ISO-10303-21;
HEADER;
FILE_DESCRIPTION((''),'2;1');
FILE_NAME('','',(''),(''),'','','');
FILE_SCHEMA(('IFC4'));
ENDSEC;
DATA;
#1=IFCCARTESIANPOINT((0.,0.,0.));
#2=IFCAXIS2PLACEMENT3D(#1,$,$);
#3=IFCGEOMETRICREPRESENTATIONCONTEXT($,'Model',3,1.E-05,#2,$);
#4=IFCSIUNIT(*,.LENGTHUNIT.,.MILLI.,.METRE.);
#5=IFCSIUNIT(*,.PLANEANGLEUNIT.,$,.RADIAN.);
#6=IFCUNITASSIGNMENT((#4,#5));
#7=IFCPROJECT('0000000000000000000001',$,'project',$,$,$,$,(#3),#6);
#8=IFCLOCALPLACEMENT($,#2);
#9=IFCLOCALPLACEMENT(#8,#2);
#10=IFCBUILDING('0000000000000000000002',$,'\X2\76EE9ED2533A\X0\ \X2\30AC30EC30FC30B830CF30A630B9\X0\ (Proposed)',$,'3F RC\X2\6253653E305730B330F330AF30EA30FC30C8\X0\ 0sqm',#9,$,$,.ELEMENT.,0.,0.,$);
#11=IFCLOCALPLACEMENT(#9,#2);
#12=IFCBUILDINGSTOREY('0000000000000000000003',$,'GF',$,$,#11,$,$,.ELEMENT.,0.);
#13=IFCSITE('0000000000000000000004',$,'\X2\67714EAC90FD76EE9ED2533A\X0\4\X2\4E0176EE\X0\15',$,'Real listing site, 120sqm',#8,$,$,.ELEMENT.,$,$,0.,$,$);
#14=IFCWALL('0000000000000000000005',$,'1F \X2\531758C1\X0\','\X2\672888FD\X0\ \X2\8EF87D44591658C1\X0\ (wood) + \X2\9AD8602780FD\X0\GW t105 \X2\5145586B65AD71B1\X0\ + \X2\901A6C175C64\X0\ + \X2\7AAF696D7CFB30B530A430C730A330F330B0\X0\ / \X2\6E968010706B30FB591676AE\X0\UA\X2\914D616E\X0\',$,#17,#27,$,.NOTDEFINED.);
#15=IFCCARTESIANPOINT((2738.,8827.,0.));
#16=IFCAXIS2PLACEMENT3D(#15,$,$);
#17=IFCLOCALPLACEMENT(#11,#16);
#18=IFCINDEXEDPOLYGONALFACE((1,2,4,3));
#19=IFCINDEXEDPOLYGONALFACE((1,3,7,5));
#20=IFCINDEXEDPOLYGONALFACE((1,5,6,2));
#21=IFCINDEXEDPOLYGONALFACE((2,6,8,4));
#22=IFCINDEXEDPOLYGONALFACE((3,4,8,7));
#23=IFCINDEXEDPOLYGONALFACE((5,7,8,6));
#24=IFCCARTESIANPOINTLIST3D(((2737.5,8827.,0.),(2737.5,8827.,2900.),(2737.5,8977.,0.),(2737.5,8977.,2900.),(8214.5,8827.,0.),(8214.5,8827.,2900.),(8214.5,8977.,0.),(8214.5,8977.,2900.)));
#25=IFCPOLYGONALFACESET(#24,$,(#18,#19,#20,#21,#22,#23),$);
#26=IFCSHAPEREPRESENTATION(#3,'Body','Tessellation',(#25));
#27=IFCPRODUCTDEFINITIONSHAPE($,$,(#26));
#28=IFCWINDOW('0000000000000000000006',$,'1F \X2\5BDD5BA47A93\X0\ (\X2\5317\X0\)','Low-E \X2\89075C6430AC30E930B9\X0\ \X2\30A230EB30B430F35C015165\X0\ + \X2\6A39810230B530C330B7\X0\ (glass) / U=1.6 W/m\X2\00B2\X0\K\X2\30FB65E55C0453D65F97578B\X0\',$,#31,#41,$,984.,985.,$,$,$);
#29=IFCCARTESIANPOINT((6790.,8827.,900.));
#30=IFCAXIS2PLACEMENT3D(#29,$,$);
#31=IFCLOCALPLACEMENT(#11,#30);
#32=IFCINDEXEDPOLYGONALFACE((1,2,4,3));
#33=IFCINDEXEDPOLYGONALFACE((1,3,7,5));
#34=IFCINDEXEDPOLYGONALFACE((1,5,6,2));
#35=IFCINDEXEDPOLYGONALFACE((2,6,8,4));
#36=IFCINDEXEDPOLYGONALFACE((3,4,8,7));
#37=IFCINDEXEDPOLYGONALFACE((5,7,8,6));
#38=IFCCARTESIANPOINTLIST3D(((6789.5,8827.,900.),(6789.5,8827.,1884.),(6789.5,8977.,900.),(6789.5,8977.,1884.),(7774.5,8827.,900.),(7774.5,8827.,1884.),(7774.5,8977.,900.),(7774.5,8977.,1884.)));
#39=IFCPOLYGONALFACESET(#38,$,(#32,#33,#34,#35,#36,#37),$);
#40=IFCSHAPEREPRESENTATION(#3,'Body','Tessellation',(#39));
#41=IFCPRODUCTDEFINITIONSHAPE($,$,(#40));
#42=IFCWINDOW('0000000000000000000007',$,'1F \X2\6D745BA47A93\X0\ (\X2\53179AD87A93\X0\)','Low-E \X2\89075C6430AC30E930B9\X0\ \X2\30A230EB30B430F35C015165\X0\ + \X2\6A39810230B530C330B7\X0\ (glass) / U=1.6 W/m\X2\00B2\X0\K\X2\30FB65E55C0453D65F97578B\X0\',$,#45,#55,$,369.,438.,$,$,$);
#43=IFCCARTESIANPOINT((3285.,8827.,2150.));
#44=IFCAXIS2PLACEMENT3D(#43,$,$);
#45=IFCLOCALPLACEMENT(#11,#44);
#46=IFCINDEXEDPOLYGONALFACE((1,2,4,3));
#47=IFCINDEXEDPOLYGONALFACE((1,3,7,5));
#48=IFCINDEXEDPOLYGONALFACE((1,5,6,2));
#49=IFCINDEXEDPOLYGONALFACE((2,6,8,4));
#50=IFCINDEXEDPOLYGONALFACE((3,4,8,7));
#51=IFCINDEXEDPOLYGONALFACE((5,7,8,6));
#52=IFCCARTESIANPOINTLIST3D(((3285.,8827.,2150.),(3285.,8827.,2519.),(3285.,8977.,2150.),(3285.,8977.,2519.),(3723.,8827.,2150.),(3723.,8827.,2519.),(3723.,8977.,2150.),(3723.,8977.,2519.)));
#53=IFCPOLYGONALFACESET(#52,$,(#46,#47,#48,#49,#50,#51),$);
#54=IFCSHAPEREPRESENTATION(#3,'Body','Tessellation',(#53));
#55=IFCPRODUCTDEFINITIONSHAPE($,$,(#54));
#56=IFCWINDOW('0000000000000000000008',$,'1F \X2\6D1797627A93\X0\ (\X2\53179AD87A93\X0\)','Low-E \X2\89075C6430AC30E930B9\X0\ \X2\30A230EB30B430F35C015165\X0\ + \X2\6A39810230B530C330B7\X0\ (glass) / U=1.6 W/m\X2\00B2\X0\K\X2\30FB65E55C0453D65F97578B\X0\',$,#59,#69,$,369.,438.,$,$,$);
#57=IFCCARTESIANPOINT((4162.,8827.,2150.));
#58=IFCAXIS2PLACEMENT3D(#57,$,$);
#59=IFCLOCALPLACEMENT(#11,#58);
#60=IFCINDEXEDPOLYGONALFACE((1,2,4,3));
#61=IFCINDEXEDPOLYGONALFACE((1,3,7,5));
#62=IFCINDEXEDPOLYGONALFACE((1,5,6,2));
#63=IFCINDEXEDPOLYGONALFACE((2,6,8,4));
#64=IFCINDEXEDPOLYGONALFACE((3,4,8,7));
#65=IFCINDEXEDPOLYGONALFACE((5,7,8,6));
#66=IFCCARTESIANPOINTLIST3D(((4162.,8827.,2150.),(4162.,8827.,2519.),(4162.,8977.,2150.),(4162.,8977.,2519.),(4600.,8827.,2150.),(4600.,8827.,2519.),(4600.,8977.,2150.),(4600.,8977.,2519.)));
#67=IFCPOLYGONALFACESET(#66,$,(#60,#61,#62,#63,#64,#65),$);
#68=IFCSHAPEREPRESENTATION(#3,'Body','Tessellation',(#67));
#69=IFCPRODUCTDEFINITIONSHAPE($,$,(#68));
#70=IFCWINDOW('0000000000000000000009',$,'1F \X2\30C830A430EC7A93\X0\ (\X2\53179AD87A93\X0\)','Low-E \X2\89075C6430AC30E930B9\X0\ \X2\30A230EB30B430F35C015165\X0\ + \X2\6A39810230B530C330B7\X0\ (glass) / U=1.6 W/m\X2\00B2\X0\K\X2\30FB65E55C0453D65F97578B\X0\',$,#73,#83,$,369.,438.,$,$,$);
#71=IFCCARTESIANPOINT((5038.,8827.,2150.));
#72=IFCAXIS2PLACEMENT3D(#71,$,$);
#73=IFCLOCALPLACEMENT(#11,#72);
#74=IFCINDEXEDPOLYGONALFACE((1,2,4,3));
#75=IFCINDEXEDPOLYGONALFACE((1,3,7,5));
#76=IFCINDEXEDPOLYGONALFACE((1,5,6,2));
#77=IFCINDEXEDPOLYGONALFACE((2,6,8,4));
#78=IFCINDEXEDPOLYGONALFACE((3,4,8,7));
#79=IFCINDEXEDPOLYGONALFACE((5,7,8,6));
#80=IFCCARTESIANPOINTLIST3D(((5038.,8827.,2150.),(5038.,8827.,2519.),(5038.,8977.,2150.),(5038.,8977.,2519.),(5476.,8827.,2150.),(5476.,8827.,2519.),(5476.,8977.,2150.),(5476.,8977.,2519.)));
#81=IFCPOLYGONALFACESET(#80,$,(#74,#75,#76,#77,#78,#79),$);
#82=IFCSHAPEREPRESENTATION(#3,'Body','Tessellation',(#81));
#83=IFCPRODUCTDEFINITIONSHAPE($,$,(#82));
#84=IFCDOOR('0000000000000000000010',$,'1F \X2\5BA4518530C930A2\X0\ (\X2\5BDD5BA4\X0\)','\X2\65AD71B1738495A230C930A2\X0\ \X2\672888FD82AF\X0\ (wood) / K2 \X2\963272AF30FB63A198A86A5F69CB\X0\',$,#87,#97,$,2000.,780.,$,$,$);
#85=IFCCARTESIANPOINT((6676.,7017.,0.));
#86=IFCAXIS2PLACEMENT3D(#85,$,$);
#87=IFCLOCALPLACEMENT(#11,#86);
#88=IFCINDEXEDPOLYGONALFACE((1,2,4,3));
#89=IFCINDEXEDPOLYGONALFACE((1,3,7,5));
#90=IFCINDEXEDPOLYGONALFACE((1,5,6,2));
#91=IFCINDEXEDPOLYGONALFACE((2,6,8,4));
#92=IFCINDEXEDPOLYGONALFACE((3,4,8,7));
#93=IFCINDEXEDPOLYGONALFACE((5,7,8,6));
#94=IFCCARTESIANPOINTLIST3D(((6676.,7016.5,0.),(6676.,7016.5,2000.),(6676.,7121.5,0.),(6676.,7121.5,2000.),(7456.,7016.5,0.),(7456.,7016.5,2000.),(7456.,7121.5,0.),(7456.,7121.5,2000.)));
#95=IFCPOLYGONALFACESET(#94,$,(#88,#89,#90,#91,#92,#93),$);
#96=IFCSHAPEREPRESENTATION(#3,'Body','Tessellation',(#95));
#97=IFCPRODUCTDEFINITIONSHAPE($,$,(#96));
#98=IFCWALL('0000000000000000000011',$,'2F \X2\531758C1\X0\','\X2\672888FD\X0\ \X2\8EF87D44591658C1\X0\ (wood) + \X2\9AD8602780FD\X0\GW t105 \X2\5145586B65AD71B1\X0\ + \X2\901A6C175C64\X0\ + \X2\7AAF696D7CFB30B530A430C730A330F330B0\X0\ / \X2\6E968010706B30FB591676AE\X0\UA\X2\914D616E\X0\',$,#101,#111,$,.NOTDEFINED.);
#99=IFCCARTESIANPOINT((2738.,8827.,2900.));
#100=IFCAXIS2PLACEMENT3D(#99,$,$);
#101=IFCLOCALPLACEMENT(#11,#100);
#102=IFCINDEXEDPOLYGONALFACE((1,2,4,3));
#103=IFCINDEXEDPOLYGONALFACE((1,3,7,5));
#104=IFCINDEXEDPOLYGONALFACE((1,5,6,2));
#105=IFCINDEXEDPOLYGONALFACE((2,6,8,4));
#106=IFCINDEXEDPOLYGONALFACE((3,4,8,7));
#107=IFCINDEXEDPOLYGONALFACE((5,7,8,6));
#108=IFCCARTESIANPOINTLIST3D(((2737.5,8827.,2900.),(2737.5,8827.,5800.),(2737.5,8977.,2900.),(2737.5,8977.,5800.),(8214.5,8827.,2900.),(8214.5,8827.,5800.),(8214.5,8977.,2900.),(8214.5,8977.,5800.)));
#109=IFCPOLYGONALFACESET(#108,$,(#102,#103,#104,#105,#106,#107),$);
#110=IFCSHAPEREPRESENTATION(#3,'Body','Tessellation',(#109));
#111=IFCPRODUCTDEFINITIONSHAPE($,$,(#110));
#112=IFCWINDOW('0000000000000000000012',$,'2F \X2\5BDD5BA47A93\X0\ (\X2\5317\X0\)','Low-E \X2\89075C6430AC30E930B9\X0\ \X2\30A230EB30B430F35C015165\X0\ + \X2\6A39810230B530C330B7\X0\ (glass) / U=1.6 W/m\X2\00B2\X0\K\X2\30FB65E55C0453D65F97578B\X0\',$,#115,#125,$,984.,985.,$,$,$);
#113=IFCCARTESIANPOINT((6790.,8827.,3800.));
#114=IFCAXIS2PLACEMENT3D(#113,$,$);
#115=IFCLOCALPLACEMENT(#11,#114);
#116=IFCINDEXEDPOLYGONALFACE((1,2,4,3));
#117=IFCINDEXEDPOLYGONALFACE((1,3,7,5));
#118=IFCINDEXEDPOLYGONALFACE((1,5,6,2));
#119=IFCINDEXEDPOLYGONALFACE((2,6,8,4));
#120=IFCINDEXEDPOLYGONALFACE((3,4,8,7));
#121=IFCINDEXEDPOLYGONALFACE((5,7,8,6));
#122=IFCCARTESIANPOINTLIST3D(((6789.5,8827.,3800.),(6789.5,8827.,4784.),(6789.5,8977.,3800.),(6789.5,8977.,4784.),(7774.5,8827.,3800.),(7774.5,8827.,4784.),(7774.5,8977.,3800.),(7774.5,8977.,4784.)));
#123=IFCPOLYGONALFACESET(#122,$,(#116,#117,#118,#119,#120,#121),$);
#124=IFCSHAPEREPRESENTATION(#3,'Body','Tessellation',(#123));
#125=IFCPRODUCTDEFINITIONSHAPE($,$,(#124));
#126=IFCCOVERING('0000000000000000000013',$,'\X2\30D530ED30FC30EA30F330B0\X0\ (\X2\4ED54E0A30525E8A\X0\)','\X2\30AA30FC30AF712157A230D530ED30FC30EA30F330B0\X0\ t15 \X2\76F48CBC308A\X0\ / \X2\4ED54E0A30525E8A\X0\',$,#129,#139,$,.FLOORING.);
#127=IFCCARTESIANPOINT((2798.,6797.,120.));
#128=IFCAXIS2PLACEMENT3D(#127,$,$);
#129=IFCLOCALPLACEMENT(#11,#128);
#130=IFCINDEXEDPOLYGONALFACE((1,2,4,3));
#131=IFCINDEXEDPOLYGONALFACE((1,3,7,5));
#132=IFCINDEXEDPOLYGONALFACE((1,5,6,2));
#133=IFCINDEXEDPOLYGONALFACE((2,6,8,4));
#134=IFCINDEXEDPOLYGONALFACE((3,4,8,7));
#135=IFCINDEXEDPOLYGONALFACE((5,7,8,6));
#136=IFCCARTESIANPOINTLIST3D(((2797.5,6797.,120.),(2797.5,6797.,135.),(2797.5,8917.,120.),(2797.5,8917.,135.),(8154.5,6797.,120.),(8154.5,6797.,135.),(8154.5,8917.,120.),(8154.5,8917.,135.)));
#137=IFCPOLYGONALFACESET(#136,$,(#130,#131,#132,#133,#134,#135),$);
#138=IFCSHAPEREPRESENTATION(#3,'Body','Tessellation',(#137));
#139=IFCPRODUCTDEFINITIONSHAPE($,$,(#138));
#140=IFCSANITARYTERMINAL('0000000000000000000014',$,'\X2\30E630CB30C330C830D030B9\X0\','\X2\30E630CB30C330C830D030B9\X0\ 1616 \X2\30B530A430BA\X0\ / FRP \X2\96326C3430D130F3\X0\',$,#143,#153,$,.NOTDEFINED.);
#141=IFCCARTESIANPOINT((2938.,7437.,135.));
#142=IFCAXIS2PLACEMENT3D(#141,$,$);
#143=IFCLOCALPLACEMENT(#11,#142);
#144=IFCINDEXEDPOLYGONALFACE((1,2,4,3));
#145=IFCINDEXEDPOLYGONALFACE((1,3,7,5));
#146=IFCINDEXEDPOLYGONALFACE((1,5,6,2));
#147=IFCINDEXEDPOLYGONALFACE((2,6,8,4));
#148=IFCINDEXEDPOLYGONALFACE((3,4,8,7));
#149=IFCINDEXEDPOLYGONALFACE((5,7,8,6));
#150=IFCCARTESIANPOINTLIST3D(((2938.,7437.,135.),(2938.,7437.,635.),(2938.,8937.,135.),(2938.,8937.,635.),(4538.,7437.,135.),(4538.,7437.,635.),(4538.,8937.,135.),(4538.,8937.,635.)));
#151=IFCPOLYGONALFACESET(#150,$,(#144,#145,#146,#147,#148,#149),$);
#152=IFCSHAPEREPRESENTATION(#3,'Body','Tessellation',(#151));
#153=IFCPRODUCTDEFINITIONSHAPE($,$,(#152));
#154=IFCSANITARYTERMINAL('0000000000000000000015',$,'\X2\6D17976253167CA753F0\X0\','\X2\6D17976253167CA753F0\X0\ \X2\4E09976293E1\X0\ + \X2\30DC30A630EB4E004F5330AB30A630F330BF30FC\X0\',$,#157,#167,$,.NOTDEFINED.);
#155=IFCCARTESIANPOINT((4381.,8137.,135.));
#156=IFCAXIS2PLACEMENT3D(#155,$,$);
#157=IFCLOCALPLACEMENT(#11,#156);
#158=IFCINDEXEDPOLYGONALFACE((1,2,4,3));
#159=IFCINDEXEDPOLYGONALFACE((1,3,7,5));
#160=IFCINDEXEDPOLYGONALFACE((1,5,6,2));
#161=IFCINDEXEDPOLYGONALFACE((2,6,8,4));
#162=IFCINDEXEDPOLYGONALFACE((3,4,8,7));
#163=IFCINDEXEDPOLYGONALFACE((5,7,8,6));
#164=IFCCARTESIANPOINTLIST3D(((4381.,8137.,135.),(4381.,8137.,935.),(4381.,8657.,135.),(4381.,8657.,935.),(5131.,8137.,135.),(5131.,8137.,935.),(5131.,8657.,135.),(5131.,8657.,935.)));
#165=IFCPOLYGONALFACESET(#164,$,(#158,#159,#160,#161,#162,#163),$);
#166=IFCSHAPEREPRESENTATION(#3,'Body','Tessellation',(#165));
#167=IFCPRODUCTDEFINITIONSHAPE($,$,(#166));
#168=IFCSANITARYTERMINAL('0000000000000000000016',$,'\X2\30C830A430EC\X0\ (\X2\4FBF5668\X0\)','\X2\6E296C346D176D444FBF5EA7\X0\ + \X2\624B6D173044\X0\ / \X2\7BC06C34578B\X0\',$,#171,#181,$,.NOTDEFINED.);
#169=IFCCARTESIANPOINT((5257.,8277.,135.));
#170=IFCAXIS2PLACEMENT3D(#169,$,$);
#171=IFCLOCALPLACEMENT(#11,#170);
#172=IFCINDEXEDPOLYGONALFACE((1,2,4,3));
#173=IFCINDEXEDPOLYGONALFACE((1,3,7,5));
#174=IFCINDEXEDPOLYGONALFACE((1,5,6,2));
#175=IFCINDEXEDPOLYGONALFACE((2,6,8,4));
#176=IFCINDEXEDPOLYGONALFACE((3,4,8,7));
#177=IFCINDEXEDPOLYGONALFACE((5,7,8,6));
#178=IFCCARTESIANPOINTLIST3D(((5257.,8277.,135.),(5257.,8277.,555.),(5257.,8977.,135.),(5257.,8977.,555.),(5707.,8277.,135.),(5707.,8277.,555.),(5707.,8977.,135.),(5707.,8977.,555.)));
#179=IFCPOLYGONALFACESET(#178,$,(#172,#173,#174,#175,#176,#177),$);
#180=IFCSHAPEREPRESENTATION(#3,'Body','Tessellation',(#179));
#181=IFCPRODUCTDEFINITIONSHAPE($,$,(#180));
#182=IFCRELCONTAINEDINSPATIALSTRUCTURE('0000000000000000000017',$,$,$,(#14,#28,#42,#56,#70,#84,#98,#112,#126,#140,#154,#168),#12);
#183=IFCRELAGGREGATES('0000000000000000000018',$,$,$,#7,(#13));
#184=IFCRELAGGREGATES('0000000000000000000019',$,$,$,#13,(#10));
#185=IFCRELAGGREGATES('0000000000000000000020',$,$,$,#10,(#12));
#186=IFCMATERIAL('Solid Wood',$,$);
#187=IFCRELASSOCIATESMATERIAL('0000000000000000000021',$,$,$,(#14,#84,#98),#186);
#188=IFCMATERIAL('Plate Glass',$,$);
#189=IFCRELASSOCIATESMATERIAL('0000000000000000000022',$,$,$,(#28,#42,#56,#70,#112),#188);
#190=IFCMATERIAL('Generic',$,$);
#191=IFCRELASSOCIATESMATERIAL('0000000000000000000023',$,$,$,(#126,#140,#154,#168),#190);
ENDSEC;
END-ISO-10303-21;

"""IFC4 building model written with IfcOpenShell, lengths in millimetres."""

from ifc_helpers import new_model, si_unit, frame, frame_2d, origin, place, context, project, spatial, rectangle, extrude, material, element, fill, save


model = new_model("IFC4")

# Units and contexts
model_context = context("Model", 3, precision=1e-05, world=origin())
ifc_project = project(units=[si_unit("LENGTHUNIT", "METRE", prefix="MILLI"), si_unit("PLANEANGLEUNIT", "RADIAN")], contexts=[model_context])

# Site, building, storey
site_placement = place(None, origin())
site = spatial("IfcSite", under=ifc_project, at=site_placement, Name="東京都目黒区4丁目15", ObjectType="Real listing site, 120sqm", CompositionType="ELEMENT", RefElevation=0.0)
building_placement = place(site_placement, origin())
building = spatial("IfcBuilding", under=site, at=building_placement, Name="目黒区 ガレージハウス (Proposed)", ObjectType="3F RC打放しコンクリート 0sqm", CompositionType="ELEMENT", ElevationOfRefHeight=0.0, ElevationOfTerrain=0.0)
storey_placement = place(building_placement, origin())
storey = spatial("IfcBuildingStorey", under=building, at=storey_placement, Name="GF", CompositionType="ELEMENT", Elevation=0.0)

# Wall, openings, windows
ifc_material_1 = material(Name="Solid Wood")
wall_1_placement = place(storey_placement, frame((2738.0, 8827.0, 0.0)))
wall_1 = element("IfcWall", 1, at=wall_1_placement, inside=storey, material=ifc_material_1, Name="1F 北壁", Description="木製 軸組外壁 (wood) + 高性能GW t105 充填断熱 + 通気層 + 窯業系サイディング / 準耐火・外皮UA配慮", PredefinedType="NOTDEFINED", context=model_context, shape_type="SweptSolid", body=[
    extrude(rectangle(XDim=5477.0, YDim=150.0, at=frame_2d((2738.0, 75.0))), frame((2738.0, 8827.0, 0.0)), (0.0, 0.0, 1.0), 2900.0),
])
opening_1_placement = place(storey_placement, frame((6790.0, 8827.0, 900.0)))
opening_1 = element("IfcOpeningElement", 2, at=opening_1_placement, cuts=wall_1, PredefinedType="NOTDEFINED", context=model_context, shape_type="SweptSolid", body=[
    extrude(rectangle(XDim=985.0, YDim=150.0, at=frame_2d((492.0, 75.0))), frame((6790.0, 8827.0, 900.0)), (0.0, 0.0, 1.0), 984.0),
])
opening_2_placement = place(storey_placement, frame((3285.0, 8827.0, 2150.0)))
opening_2 = element("IfcOpeningElement", 3, at=opening_2_placement, cuts=wall_1, PredefinedType="NOTDEFINED", context=model_context, shape_type="SweptSolid", body=[
    extrude(rectangle(XDim=438.0, YDim=150.0, at=frame_2d((219.0, 75.0))), frame((3285.0, 8827.0, 2150.0)), (0.0, 0.0, 1.0), 369.0),
])
opening_3_placement = place(storey_placement, frame((4162.0, 8827.0, 2150.0)))
opening_3 = element("IfcOpeningElement", 4, at=opening_3_placement, cuts=wall_1, PredefinedType="NOTDEFINED", context=model_context, shape_type="SweptSolid", body=[
    extrude(rectangle(XDim=438.0, YDim=150.0, at=frame_2d((219.0, 75.0))), frame((4162.0, 8827.0, 2150.0)), (0.0, 0.0, 1.0), 369.0),
])
opening_4_placement = place(storey_placement, frame((5038.0, 8827.0, 2150.0)))
opening_4 = element("IfcOpeningElement", 5, at=opening_4_placement, cuts=wall_1, PredefinedType="NOTDEFINED", context=model_context, shape_type="SweptSolid", body=[
    extrude(rectangle(XDim=438.0, YDim=150.0, at=frame_2d((219.0, 75.0))), frame((5038.0, 8827.0, 2150.0)), (0.0, 0.0, 1.0), 369.0),
])
ifc_material_2 = material(Name="Plate Glass")
window_1_placement = place(storey_placement, frame((6790.0, 8827.0, 900.0)))
window_1 = element("IfcWindow", 6, at=window_1_placement, inside=storey, material=ifc_material_2, Name="1F 寝室窓 (北)", Description="Low-E 複層ガラス アルゴン封入 + 樹脂サッシ (glass) / U=1.6 W/m²K・日射取得型", OverallHeight=984.0, OverallWidth=985.0, context=model_context, shape_type="SweptSolid", body=[
    extrude(rectangle(XDim=985.0, YDim=150.0, at=frame_2d((492.0, 75.0))), frame((6790.0, 8827.0, 900.0)), (0.0, 0.0, 1.0), 984.0),
])
fill(opening_1, window_1)
window_2_placement = place(storey_placement, frame((3285.0, 8827.0, 2150.0)))
window_2 = element("IfcWindow", 7, at=window_2_placement, inside=storey, material=ifc_material_2, Name="1F 浴室窓 (北高窓)", Description="Low-E 複層ガラス アルゴン封入 + 樹脂サッシ (glass) / U=1.6 W/m²K・日射取得型", OverallHeight=369.0, OverallWidth=438.0, context=model_context, shape_type="SweptSolid", body=[
    extrude(rectangle(XDim=438.0, YDim=150.0, at=frame_2d((219.0, 75.0))), frame((3285.0, 8827.0, 2150.0)), (0.0, 0.0, 1.0), 369.0),
])
fill(opening_2, window_2)
window_3_placement = place(storey_placement, frame((4162.0, 8827.0, 2150.0)))
window_3 = element("IfcWindow", 8, at=window_3_placement, inside=storey, material=ifc_material_2, Name="1F 洗面窓 (北高窓)", Description="Low-E 複層ガラス アルゴン封入 + 樹脂サッシ (glass) / U=1.6 W/m²K・日射取得型", OverallHeight=369.0, OverallWidth=438.0, context=model_context, shape_type="SweptSolid", body=[
    extrude(rectangle(XDim=438.0, YDim=150.0, at=frame_2d((219.0, 75.0))), frame((4162.0, 8827.0, 2150.0)), (0.0, 0.0, 1.0), 369.0),
])
fill(opening_3, window_3)
window_4_placement = place(storey_placement, frame((5038.0, 8827.0, 2150.0)))
window_4 = element("IfcWindow", 9, at=window_4_placement, inside=storey, material=ifc_material_2, Name="1F トイレ窓 (北高窓)", Description="Low-E 複層ガラス アルゴン封入 + 樹脂サッシ (glass) / U=1.6 W/m²K・日射取得型", OverallHeight=369.0, OverallWidth=438.0, context=model_context, shape_type="SweptSolid", body=[
    extrude(rectangle(XDim=438.0, YDim=150.0, at=frame_2d((219.0, 75.0))), frame((5038.0, 8827.0, 2150.0)), (0.0, 0.0, 1.0), 369.0),
])
fill(opening_4, window_4)

# Door
door_1_placement = place(storey_placement, frame((6676.0, 7017.0, 0.0)))
element("IfcDoor", 10, at=door_1_placement, inside=storey, material=ifc_material_1, Name="1F 室内ドア (寝室)", Description="断熱玄関ドア 木製芯 (wood) / K2 防犯・採風機構", OverallHeight=2000.0, OverallWidth=780.0, context=model_context, shape_type="SweptSolid", body=[
    extrude(rectangle(XDim=780.0, YDim=105.0, at=frame_2d((390.0, 52.0))), frame((6676.0, 7017.0, 0.0)), (0.0, 0.0, 1.0), 2000.0),
])

# Wall, opening, window
wall_2_placement = place(storey_placement, frame((2738.0, 8827.0, 2900.0)))
wall_2 = element("IfcWall", 11, at=wall_2_placement, inside=storey, material=ifc_material_1, Name="2F 北壁", Description="木製 軸組外壁 (wood) + 高性能GW t105 充填断熱 + 通気層 + 窯業系サイディング / 準耐火・外皮UA配慮", PredefinedType="NOTDEFINED", context=model_context, shape_type="SweptSolid", body=[
    extrude(rectangle(XDim=5477.0, YDim=150.0, at=frame_2d((2738.0, 75.0))), frame((2738.0, 8827.0, 2900.0)), (0.0, 0.0, 1.0), 2900.0),
])
opening_5_placement = place(storey_placement, frame((6790.0, 8827.0, 3800.0)))
opening_5 = element("IfcOpeningElement", 12, at=opening_5_placement, cuts=wall_2, PredefinedType="NOTDEFINED", context=model_context, shape_type="SweptSolid", body=[
    extrude(rectangle(XDim=985.0, YDim=150.0, at=frame_2d((492.0, 75.0))), frame((6790.0, 8827.0, 3800.0)), (0.0, 0.0, 1.0), 984.0),
])
window_5_placement = place(storey_placement, frame((6790.0, 8827.0, 3800.0)))
window_5 = element("IfcWindow", 13, at=window_5_placement, inside=storey, material=ifc_material_2, Name="2F 寝室窓 (北)", Description="Low-E 複層ガラス アルゴン封入 + 樹脂サッシ (glass) / U=1.6 W/m²K・日射取得型", OverallHeight=984.0, OverallWidth=985.0, context=model_context, shape_type="SweptSolid", body=[
    extrude(rectangle(XDim=985.0, YDim=150.0, at=frame_2d((492.0, 75.0))), frame((6790.0, 8827.0, 3800.0)), (0.0, 0.0, 1.0), 984.0),
])
fill(opening_5, window_5)

# Covering
ifc_material_3 = material(Name="Generic")
covering_placement = place(storey_placement, frame((2798.0, 6797.0, 120.0)))
element("IfcCovering", 14, at=covering_placement, inside=storey, material=ifc_material_3, Name="フローリング (仕上げ床)", Description="オーク無垢フローリング t15 直貼り / 仕上げ床", PredefinedType="FLOORING", context=model_context, shape_type="SweptSolid", body=[
    extrude(rectangle(XDim=5357.0, YDim=2120.0, at=frame_2d((2678.0, 1060.0))), frame((2798.0, 6797.0, 120.0)), (0.0, 0.0, 1.0), 15.0),
])

# Sanitary terminals
sanitary_terminal_1_placement = place(storey_placement, frame((2938.0, 7437.0, 135.0)))
element("IfcSanitaryTerminal", 15, at=sanitary_terminal_1_placement, inside=storey, material=ifc_material_3, Name="ユニットバス", Description="ユニットバス 1616 サイズ / FRP 防水パン", PredefinedType="NOTDEFINED", context=model_context, shape_type="SweptSolid", body=[
    extrude(rectangle(XDim=1600.0, YDim=1500.0, at=frame_2d((800.0, 750.0))), frame((2938.0, 7437.0, 135.0)), (0.0, 0.0, 1.0), 500.0),
])
sanitary_terminal_2_placement = place(storey_placement, frame((4381.0, 8137.0, 135.0)))
element("IfcSanitaryTerminal", 16, at=sanitary_terminal_2_placement, inside=storey, material=ifc_material_3, Name="洗面化粧台", Description="洗面化粧台 三面鏡 + ボウル一体カウンター", PredefinedType="NOTDEFINED", context=model_context, shape_type="SweptSolid", body=[
    extrude(rectangle(XDim=750.0, YDim=520.0, at=frame_2d((375.0, 260.0))), frame((4381.0, 8137.0, 135.0)), (0.0, 0.0, 1.0), 800.0),
])
sanitary_terminal_3_placement = place(storey_placement, frame((5257.0, 8277.0, 135.0)))
element("IfcSanitaryTerminal", 17, at=sanitary_terminal_3_placement, inside=storey, material=ifc_material_3, Name="トイレ (便器)", Description="温水洗浄便座 + 手洗い / 節水型", PredefinedType="NOTDEFINED", context=model_context, shape_type="SweptSolid", body=[
    extrude(rectangle(XDim=450.0, YDim=700.0, at=frame_2d((225.0, 350.0))), frame((5257.0, 8277.0, 135.0)), (0.0, 0.0, 1.0), 420.0),
])

save(model, "model.ifc")
